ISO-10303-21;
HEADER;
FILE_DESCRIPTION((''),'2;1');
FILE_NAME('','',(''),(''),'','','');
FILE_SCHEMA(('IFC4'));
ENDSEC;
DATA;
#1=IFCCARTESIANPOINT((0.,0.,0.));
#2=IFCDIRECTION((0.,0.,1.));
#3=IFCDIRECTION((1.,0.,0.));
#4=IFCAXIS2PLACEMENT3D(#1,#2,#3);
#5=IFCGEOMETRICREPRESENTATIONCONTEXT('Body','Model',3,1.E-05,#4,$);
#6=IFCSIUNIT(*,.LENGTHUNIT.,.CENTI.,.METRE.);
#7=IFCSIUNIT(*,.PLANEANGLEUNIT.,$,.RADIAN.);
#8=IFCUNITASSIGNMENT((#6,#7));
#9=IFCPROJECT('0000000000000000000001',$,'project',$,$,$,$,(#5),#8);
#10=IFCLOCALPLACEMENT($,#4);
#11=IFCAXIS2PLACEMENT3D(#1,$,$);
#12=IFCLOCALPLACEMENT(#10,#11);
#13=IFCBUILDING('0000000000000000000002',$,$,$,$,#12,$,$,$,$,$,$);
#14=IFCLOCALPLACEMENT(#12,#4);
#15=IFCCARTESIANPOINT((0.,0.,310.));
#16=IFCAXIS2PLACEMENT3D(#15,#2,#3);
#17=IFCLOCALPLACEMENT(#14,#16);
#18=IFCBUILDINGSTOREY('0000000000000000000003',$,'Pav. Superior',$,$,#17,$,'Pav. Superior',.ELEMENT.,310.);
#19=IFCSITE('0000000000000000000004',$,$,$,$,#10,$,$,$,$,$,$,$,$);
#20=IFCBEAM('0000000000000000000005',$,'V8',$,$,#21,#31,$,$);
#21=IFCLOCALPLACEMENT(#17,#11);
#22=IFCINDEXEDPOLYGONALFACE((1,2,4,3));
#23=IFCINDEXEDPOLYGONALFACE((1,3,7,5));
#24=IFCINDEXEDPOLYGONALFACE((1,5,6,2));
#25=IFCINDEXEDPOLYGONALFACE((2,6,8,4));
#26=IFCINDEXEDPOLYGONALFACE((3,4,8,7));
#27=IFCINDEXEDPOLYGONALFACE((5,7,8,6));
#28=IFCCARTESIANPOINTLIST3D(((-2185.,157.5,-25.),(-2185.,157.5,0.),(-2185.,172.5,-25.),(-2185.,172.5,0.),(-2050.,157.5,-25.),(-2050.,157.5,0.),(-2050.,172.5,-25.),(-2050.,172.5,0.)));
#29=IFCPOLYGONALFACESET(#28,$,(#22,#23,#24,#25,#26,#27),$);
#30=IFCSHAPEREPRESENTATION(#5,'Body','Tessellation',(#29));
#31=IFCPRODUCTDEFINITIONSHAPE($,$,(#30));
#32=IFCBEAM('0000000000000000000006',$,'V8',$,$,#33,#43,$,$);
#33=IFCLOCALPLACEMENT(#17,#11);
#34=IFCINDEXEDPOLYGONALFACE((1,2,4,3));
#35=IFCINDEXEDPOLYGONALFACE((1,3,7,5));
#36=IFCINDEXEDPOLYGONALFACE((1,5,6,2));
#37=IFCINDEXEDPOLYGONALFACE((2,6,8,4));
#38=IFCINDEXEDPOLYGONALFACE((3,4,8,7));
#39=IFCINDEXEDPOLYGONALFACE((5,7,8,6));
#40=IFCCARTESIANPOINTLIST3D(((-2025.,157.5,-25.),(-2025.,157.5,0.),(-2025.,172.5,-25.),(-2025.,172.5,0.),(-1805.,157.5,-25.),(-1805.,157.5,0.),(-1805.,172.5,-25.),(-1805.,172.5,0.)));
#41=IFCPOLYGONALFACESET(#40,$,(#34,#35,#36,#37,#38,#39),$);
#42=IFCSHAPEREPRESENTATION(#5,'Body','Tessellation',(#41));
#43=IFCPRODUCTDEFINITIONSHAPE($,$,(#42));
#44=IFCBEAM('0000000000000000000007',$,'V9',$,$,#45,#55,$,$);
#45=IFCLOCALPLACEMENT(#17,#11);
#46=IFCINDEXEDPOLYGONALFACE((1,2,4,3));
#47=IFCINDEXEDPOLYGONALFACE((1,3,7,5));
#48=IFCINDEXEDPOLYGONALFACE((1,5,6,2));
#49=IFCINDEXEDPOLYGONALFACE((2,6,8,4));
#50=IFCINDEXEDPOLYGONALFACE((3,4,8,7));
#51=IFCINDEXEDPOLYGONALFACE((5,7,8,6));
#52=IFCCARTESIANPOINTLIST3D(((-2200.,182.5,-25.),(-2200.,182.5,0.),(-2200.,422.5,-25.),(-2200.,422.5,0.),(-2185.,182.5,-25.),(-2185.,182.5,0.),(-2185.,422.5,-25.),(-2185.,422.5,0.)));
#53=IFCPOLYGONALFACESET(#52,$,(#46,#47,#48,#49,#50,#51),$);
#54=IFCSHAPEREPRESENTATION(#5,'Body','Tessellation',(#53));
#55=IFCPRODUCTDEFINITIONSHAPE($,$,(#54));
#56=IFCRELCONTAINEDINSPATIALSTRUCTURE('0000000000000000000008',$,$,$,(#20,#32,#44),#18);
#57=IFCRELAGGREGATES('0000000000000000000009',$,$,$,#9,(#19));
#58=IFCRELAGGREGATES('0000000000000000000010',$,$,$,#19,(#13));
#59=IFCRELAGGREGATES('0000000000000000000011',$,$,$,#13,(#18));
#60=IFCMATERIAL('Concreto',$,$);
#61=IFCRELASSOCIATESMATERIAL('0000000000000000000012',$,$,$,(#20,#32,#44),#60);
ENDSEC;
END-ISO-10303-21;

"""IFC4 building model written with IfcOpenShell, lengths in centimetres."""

from ifc_helpers import new_model, si_unit, frame, origin, origin_with_axes, origin_2d_with_axis, place, context, project, spatial, rectangle, extrude, material, element, save


model = new_model("IFC4")

# Units and contexts
model_context = context("Model", 3, precision=1e-05, world=origin_with_axes(), identifier="Body")
ifc_project = project(units=[si_unit("LENGTHUNIT", "METRE", prefix="CENTI"), si_unit("PLANEANGLEUNIT", "RADIAN")], contexts=[model_context])

# Site, building, storey
site_placement = place(None, origin_with_axes())
site = spatial("IfcSite", under=ifc_project, at=site_placement)
building_placement = place(site_placement, origin())
building = spatial("IfcBuilding", under=site, at=building_placement)
placement = place(building_placement, origin_with_axes())
storey_placement = place(placement, frame((0.0, 0.0, 310.0), z_axis=(0.0, 0.0, 1.0), x_axis=(1.0, 0.0, 0.0)))
storey = spatial("IfcBuildingStorey", under=building, at=storey_placement, Name="Pav. Superior", LongName="Pav. Superior", CompositionType="ELEMENT", Elevation=310.0)

# Shared definitions
ifc_material = material(Name="Concreto")

# Beams
beam_1_placement = place(storey_placement, frame((-2117.5, 165.0, 0.0), z_axis=(0.0, 0.0, 1.0), x_axis=(1.0, 0.0, 0.0)))
element("IfcBeam", 1, at=beam_1_placement, inside=storey, material=ifc_material, Name="V8", context=model_context, shape_type="SolidModel", body=[
    extrude(rectangle(XDim=15.0, YDim=25.0, at=origin_2d_with_axis()), frame((-67.5, 0.0, -12.5), z_axis=(1.0, 0.0, 0.0), x_axis=(0.0, -1.0, 0.0)), (0.0, 0.0, 1.0), 135.0),
])
beam_2_placement = place(storey_placement, frame((-1915.0, 165.0, 0.0), z_axis=(0.0, 0.0, 1.0), x_axis=(1.0, 0.0, 0.0)))
element("IfcBeam", 2, at=beam_2_placement, inside=storey, material=ifc_material, Name="V8", context=model_context, shape_type="SolidModel", body=[
    extrude(rectangle(XDim=15.0, YDim=25.0, at=origin_2d_with_axis()), frame((-110.0, 0.0, -12.5), z_axis=(1.0, 0.0, 0.0), x_axis=(0.0, -1.0, 0.0)), (0.0, 0.0, 1.0), 220.0),
])
beam_3_placement = place(storey_placement, frame((-2192.5, 302.5, 0.0), z_axis=(0.0, 0.0, 1.0), x_axis=(1.0, 0.0, 0.0)))
element("IfcBeam", 3, at=beam_3_placement, inside=storey, material=ifc_material, Name="V9", context=model_context, shape_type="SolidModel", body=[
    extrude(rectangle(XDim=15.0, YDim=25.0, at=origin_2d_with_axis()), frame((0.0, -120.0, -12.5), z_axis=(0.0, 1.0, 0.0), x_axis=(-1.0, 0.0, 0.0)), (0.0, 0.0, 1.0), 240.0),
])

save(model, "model.ifc")
